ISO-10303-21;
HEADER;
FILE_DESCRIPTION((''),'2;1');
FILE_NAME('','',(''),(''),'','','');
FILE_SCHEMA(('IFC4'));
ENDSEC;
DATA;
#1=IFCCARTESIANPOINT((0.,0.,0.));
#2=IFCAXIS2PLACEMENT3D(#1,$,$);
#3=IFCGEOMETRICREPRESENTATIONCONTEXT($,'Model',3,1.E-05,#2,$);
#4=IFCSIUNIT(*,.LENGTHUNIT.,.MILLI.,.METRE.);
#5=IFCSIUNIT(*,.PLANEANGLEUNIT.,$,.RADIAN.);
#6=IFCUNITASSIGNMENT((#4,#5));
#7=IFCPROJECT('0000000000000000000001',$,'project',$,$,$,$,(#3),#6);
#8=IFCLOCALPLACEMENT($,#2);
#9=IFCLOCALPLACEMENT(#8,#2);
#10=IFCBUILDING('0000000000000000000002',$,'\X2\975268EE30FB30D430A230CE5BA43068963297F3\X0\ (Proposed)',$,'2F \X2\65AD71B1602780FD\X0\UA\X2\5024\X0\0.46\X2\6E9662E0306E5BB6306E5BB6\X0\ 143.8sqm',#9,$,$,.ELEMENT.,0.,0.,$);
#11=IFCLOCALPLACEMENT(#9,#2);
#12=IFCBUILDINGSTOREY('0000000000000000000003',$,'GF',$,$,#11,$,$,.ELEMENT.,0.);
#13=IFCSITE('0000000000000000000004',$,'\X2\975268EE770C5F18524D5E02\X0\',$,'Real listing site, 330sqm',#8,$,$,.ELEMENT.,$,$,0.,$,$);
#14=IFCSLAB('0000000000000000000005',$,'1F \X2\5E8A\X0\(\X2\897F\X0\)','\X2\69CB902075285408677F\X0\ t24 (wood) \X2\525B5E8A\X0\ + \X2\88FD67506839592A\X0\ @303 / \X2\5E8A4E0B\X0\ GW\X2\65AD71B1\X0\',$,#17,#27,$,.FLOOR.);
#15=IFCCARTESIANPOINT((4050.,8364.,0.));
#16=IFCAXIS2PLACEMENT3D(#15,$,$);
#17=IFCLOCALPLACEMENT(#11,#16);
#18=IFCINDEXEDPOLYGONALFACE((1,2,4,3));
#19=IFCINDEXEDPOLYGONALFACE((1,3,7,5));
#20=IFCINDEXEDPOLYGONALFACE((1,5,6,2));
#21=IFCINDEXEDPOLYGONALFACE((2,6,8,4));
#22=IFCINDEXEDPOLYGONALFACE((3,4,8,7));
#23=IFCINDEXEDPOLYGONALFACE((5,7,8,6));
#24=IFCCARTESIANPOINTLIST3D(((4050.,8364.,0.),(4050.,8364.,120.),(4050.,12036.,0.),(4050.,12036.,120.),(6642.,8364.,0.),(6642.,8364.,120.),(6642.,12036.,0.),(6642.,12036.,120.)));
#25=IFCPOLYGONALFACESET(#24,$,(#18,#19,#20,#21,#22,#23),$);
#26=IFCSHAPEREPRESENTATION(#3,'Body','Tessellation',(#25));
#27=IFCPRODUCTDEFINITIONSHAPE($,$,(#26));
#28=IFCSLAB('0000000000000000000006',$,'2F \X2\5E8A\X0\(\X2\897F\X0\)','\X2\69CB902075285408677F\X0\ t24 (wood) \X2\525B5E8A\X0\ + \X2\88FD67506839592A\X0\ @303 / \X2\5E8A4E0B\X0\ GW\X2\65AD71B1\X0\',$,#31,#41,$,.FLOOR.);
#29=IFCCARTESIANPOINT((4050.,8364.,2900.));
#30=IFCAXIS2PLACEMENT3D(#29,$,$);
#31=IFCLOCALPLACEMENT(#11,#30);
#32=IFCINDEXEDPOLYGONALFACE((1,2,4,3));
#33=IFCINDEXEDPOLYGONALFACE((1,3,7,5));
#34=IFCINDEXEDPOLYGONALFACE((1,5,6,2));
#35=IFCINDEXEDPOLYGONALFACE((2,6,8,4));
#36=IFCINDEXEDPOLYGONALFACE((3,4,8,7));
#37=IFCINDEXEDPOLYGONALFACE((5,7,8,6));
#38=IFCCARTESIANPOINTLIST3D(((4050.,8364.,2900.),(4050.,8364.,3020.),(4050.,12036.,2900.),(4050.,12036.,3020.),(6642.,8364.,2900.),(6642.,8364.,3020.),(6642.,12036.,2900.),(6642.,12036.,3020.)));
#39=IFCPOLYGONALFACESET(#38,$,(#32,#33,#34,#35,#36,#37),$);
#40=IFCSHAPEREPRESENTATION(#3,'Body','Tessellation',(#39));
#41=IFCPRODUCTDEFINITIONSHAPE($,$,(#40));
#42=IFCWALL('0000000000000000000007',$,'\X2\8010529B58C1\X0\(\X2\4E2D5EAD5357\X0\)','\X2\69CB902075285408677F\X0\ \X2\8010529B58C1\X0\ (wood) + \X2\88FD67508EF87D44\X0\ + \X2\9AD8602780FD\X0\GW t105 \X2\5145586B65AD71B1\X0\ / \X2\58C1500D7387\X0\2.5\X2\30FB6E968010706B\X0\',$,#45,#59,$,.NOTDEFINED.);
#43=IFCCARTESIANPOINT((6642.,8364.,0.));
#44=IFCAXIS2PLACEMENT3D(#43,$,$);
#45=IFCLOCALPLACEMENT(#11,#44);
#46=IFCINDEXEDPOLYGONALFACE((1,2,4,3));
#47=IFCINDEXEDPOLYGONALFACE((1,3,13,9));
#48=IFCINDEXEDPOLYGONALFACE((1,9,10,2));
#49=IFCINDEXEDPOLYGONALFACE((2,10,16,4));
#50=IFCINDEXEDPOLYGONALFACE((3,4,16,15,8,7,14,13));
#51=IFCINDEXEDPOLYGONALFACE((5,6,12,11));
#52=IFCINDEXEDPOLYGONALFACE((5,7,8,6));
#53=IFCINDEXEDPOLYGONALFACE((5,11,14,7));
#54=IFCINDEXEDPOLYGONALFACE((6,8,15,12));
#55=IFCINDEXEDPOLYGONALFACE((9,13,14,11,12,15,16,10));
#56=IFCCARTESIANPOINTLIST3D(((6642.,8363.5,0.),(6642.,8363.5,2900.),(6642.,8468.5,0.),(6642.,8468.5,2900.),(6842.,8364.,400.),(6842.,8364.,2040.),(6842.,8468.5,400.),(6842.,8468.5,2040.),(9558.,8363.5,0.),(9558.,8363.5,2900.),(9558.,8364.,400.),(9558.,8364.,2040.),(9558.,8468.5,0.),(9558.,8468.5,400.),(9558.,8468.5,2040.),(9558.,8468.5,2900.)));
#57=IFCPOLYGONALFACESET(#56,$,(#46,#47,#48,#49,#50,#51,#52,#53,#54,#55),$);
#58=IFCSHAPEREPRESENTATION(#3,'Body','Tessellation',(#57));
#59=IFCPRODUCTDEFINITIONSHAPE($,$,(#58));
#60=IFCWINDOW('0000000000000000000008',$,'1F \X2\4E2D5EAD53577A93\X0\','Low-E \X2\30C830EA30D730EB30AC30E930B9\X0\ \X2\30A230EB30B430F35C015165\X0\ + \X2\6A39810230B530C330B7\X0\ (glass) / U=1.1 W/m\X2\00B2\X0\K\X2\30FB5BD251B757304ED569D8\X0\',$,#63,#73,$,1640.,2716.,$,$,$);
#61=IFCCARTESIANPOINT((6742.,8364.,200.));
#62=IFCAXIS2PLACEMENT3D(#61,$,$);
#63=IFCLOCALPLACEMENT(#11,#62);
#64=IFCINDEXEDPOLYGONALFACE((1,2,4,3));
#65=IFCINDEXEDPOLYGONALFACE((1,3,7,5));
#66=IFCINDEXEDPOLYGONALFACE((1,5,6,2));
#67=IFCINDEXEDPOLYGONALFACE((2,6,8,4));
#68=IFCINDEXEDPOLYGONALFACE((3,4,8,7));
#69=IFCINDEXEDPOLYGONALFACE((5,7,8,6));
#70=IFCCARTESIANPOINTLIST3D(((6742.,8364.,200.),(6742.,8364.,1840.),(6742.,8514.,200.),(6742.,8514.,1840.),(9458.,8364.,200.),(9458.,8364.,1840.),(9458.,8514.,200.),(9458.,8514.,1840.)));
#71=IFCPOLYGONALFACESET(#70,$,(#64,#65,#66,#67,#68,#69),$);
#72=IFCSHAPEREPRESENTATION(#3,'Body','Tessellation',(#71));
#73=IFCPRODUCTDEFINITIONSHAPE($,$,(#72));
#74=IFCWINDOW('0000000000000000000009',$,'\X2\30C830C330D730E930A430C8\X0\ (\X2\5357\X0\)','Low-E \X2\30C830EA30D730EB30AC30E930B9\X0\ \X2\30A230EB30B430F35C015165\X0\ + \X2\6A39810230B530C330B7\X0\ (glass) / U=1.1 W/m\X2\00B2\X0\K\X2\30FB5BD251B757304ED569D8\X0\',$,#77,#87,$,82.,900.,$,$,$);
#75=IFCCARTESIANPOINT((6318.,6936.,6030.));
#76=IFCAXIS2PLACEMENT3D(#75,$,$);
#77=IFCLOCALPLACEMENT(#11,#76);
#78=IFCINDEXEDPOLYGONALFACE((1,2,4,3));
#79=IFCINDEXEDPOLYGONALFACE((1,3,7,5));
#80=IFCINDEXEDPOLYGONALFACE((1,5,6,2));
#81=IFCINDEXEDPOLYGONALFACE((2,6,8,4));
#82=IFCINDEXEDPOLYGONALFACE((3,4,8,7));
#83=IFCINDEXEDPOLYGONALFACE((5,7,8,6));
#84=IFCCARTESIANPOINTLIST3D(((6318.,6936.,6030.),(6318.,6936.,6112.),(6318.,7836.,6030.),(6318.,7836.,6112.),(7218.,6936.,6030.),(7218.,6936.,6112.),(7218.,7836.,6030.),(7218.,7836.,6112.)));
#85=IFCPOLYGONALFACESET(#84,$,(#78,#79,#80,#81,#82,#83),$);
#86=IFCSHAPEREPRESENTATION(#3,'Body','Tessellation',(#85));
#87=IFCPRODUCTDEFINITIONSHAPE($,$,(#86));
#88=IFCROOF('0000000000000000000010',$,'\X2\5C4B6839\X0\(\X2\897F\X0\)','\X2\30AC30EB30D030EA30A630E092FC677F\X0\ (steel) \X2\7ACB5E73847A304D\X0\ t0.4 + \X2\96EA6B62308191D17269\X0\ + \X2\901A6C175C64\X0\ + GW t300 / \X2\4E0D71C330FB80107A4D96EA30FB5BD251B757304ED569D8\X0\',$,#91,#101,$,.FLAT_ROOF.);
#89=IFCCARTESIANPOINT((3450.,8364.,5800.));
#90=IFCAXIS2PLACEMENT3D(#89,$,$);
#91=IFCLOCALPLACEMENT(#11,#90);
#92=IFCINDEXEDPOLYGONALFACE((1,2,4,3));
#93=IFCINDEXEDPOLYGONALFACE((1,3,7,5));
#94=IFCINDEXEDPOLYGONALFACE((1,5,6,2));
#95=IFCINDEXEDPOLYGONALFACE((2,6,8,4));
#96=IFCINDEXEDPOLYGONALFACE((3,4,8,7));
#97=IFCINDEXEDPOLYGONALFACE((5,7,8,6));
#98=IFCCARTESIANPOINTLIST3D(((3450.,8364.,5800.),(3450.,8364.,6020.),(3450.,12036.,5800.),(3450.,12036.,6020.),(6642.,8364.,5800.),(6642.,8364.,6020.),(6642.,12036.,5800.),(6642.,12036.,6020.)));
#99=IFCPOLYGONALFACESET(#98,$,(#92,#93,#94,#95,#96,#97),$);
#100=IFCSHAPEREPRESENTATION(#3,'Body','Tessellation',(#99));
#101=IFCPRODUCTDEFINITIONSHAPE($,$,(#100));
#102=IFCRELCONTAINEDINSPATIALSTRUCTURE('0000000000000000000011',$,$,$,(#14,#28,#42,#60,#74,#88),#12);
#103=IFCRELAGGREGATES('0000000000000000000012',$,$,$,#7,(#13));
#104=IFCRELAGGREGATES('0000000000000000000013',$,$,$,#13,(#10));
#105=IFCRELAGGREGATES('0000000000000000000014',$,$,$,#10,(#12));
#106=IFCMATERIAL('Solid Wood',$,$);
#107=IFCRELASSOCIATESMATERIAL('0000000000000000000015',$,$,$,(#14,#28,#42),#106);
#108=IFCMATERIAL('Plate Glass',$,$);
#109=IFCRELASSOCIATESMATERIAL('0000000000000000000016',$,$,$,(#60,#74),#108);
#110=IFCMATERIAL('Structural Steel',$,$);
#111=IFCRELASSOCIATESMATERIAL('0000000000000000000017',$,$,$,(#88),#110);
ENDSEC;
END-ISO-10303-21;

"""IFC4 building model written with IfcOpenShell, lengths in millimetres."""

from ifc_helpers import new_model, si_unit, frame, frame_2d, origin, place, context, project, spatial, rectangle, extrude, material, element, fill, save


model = new_model("IFC4")

# Units and contexts
model_context = context("Model", 3, precision=1e-05, world=origin())
ifc_project = project(units=[si_unit("LENGTHUNIT", "METRE", prefix="MILLI"), si_unit("PLANEANGLEUNIT", "RADIAN")], contexts=[model_context])

# Site, building, storey
site_placement = place(None, origin())
site = spatial("IfcSite", under=ifc_project, at=site_placement, Name="青森県弘前市", ObjectType="Real listing site, 330sqm", CompositionType="ELEMENT", RefElevation=0.0)
building_placement = place(site_placement, origin())
building = spatial("IfcBuilding", under=site, at=building_placement, Name="青森・ピアノ室と防音 (Proposed)", ObjectType="2F 断熱性能UA値0.46準拠の家の家 143.8sqm", CompositionType="ELEMENT", ElevationOfRefHeight=0.0, ElevationOfTerrain=0.0)
storey_placement = place(building_placement, origin())
storey = spatial("IfcBuildingStorey", under=building, at=storey_placement, Name="GF", CompositionType="ELEMENT", Elevation=0.0)

# Shared definitions
ifc_material_1 = material(Name="Solid Wood")

# Slabs
slab_1_placement = place(storey_placement, frame((4050.0, 8364.0, 0.0)))
element("IfcSlab", 1, at=slab_1_placement, inside=storey, material=ifc_material_1, Name="1F 床(西)", Description="構造用合板 t24 (wood) 剛床 + 製材根太 @303 / 床下 GW断熱", PredefinedType="FLOOR", context=model_context, shape_type="SweptSolid", body=[
    extrude(rectangle(XDim=2592.0, YDim=3672.0, at=frame_2d((1296.0, 1836.0))), frame((4050.0, 8364.0, 0.0)), (0.0, 0.0, 1.0), 120.0),
])
slab_2_placement = place(storey_placement, frame((4050.0, 8364.0, 2900.0)))
element("IfcSlab", 2, at=slab_2_placement, inside=storey, material=ifc_material_1, Name="2F 床(西)", Description="構造用合板 t24 (wood) 剛床 + 製材根太 @303 / 床下 GW断熱", PredefinedType="FLOOR", context=model_context, shape_type="SweptSolid", body=[
    extrude(rectangle(XDim=2592.0, YDim=3672.0, at=frame_2d((1296.0, 1836.0))), frame((4050.0, 8364.0, 2900.0)), (0.0, 0.0, 1.0), 120.0),
])

# Wall, opening, window
wall_1_placement = place(storey_placement, frame((6642.0, 8364.0, 0.0)))
wall_1 = element("IfcWall", 3, at=wall_1_placement, inside=storey, material=ifc_material_1, Name="耐力壁(中庭南)", Description="構造用合板 耐力壁 (wood) + 製材軸組 + 高性能GW t105 充填断熱 / 壁倍率2.5・準耐火", PredefinedType="NOTDEFINED", context=model_context, shape_type="SweptSolid", body=[
    extrude(rectangle(XDim=2916.0, YDim=105.0, at=frame_2d((1458.0, 52.0))), frame((6642.0, 8364.0, 0.0)), (0.0, 0.0, 1.0), 2900.0),
])
opening_placement = place(storey_placement, frame((6742.0, 8364.0, 200.0)))
opening = element("IfcOpeningElement", 4, at=opening_placement, cuts=wall_1, PredefinedType="NOTDEFINED", context=model_context, shape_type="SweptSolid", body=[
    extrude(rectangle(XDim=2716.0, YDim=150.0, at=frame_2d((1358.0, 75.0))), frame((6742.0, 8364.0, 200.0)), (0.0, 0.0, 1.0), 1640.0),
])
ifc_material_2 = material(Name="Plate Glass")
window_1_placement = place(storey_placement, frame((6742.0, 8364.0, 200.0)))
window_1 = element("IfcWindow", 5, at=window_1_placement, inside=storey, material=ifc_material_2, Name="1F 中庭南窓", Description="Low-E トリプルガラス アルゴン封入 + 樹脂サッシ (glass) / U=1.1 W/m²K・寒冷地仕様", OverallHeight=1640.0, OverallWidth=2716.0, context=model_context, shape_type="SweptSolid", body=[
    extrude(rectangle(XDim=2716.0, YDim=150.0, at=frame_2d((1358.0, 75.0))), frame((6742.0, 8364.0, 200.0)), (0.0, 0.0, 1.0), 1640.0),
])
fill(opening, window_1)

# Window
window_2_placement = place(storey_placement, frame((6318.0, 6936.0, 6030.0)))
element("IfcWindow", 6, at=window_2_placement, inside=storey, material=ifc_material_2, Name="トップライト (南)", Description="Low-E トリプルガラス アルゴン封入 + 樹脂サッシ (glass) / U=1.1 W/m²K・寒冷地仕様", OverallHeight=82.0, OverallWidth=900.0, context=model_context, shape_type="SweptSolid", body=[
    extrude(rectangle(XDim=900.0, YDim=900.0, at=frame_2d((450.0, 450.0))), frame((6318.0, 6936.0, 6030.0)), (0.0, 0.0, 1.0), 82.0),
])

# Roof
ifc_material_3 = material(Name="Structural Steel")
for number, where, name in (
    (7, (3450.0, 8364.0, 5800.0), "屋根(西)"),
):
    element("IfcRoof", number, at=place(storey_placement, frame(where)), inside=storey, material=ifc_material_3, Name=name, Description="ガルバリウム鋼板 (steel) 立平葺き t0.4 + 雪止め金物 + 通気層 + GW t300 / 不燃・耐積雪・寒冷地仕様", PredefinedType="FLAT_ROOF", context=model_context, shape_type="SweptSolid", body=[
        extrude(rectangle(XDim=3192.0, YDim=3672.0, at=frame_2d((1596.0, 1836.0))), frame((3450.0, 8364.0, 5800.0)), (0.0, 0.0, 1.0), 220.0),
    ])

save(model, "model.ifc")
